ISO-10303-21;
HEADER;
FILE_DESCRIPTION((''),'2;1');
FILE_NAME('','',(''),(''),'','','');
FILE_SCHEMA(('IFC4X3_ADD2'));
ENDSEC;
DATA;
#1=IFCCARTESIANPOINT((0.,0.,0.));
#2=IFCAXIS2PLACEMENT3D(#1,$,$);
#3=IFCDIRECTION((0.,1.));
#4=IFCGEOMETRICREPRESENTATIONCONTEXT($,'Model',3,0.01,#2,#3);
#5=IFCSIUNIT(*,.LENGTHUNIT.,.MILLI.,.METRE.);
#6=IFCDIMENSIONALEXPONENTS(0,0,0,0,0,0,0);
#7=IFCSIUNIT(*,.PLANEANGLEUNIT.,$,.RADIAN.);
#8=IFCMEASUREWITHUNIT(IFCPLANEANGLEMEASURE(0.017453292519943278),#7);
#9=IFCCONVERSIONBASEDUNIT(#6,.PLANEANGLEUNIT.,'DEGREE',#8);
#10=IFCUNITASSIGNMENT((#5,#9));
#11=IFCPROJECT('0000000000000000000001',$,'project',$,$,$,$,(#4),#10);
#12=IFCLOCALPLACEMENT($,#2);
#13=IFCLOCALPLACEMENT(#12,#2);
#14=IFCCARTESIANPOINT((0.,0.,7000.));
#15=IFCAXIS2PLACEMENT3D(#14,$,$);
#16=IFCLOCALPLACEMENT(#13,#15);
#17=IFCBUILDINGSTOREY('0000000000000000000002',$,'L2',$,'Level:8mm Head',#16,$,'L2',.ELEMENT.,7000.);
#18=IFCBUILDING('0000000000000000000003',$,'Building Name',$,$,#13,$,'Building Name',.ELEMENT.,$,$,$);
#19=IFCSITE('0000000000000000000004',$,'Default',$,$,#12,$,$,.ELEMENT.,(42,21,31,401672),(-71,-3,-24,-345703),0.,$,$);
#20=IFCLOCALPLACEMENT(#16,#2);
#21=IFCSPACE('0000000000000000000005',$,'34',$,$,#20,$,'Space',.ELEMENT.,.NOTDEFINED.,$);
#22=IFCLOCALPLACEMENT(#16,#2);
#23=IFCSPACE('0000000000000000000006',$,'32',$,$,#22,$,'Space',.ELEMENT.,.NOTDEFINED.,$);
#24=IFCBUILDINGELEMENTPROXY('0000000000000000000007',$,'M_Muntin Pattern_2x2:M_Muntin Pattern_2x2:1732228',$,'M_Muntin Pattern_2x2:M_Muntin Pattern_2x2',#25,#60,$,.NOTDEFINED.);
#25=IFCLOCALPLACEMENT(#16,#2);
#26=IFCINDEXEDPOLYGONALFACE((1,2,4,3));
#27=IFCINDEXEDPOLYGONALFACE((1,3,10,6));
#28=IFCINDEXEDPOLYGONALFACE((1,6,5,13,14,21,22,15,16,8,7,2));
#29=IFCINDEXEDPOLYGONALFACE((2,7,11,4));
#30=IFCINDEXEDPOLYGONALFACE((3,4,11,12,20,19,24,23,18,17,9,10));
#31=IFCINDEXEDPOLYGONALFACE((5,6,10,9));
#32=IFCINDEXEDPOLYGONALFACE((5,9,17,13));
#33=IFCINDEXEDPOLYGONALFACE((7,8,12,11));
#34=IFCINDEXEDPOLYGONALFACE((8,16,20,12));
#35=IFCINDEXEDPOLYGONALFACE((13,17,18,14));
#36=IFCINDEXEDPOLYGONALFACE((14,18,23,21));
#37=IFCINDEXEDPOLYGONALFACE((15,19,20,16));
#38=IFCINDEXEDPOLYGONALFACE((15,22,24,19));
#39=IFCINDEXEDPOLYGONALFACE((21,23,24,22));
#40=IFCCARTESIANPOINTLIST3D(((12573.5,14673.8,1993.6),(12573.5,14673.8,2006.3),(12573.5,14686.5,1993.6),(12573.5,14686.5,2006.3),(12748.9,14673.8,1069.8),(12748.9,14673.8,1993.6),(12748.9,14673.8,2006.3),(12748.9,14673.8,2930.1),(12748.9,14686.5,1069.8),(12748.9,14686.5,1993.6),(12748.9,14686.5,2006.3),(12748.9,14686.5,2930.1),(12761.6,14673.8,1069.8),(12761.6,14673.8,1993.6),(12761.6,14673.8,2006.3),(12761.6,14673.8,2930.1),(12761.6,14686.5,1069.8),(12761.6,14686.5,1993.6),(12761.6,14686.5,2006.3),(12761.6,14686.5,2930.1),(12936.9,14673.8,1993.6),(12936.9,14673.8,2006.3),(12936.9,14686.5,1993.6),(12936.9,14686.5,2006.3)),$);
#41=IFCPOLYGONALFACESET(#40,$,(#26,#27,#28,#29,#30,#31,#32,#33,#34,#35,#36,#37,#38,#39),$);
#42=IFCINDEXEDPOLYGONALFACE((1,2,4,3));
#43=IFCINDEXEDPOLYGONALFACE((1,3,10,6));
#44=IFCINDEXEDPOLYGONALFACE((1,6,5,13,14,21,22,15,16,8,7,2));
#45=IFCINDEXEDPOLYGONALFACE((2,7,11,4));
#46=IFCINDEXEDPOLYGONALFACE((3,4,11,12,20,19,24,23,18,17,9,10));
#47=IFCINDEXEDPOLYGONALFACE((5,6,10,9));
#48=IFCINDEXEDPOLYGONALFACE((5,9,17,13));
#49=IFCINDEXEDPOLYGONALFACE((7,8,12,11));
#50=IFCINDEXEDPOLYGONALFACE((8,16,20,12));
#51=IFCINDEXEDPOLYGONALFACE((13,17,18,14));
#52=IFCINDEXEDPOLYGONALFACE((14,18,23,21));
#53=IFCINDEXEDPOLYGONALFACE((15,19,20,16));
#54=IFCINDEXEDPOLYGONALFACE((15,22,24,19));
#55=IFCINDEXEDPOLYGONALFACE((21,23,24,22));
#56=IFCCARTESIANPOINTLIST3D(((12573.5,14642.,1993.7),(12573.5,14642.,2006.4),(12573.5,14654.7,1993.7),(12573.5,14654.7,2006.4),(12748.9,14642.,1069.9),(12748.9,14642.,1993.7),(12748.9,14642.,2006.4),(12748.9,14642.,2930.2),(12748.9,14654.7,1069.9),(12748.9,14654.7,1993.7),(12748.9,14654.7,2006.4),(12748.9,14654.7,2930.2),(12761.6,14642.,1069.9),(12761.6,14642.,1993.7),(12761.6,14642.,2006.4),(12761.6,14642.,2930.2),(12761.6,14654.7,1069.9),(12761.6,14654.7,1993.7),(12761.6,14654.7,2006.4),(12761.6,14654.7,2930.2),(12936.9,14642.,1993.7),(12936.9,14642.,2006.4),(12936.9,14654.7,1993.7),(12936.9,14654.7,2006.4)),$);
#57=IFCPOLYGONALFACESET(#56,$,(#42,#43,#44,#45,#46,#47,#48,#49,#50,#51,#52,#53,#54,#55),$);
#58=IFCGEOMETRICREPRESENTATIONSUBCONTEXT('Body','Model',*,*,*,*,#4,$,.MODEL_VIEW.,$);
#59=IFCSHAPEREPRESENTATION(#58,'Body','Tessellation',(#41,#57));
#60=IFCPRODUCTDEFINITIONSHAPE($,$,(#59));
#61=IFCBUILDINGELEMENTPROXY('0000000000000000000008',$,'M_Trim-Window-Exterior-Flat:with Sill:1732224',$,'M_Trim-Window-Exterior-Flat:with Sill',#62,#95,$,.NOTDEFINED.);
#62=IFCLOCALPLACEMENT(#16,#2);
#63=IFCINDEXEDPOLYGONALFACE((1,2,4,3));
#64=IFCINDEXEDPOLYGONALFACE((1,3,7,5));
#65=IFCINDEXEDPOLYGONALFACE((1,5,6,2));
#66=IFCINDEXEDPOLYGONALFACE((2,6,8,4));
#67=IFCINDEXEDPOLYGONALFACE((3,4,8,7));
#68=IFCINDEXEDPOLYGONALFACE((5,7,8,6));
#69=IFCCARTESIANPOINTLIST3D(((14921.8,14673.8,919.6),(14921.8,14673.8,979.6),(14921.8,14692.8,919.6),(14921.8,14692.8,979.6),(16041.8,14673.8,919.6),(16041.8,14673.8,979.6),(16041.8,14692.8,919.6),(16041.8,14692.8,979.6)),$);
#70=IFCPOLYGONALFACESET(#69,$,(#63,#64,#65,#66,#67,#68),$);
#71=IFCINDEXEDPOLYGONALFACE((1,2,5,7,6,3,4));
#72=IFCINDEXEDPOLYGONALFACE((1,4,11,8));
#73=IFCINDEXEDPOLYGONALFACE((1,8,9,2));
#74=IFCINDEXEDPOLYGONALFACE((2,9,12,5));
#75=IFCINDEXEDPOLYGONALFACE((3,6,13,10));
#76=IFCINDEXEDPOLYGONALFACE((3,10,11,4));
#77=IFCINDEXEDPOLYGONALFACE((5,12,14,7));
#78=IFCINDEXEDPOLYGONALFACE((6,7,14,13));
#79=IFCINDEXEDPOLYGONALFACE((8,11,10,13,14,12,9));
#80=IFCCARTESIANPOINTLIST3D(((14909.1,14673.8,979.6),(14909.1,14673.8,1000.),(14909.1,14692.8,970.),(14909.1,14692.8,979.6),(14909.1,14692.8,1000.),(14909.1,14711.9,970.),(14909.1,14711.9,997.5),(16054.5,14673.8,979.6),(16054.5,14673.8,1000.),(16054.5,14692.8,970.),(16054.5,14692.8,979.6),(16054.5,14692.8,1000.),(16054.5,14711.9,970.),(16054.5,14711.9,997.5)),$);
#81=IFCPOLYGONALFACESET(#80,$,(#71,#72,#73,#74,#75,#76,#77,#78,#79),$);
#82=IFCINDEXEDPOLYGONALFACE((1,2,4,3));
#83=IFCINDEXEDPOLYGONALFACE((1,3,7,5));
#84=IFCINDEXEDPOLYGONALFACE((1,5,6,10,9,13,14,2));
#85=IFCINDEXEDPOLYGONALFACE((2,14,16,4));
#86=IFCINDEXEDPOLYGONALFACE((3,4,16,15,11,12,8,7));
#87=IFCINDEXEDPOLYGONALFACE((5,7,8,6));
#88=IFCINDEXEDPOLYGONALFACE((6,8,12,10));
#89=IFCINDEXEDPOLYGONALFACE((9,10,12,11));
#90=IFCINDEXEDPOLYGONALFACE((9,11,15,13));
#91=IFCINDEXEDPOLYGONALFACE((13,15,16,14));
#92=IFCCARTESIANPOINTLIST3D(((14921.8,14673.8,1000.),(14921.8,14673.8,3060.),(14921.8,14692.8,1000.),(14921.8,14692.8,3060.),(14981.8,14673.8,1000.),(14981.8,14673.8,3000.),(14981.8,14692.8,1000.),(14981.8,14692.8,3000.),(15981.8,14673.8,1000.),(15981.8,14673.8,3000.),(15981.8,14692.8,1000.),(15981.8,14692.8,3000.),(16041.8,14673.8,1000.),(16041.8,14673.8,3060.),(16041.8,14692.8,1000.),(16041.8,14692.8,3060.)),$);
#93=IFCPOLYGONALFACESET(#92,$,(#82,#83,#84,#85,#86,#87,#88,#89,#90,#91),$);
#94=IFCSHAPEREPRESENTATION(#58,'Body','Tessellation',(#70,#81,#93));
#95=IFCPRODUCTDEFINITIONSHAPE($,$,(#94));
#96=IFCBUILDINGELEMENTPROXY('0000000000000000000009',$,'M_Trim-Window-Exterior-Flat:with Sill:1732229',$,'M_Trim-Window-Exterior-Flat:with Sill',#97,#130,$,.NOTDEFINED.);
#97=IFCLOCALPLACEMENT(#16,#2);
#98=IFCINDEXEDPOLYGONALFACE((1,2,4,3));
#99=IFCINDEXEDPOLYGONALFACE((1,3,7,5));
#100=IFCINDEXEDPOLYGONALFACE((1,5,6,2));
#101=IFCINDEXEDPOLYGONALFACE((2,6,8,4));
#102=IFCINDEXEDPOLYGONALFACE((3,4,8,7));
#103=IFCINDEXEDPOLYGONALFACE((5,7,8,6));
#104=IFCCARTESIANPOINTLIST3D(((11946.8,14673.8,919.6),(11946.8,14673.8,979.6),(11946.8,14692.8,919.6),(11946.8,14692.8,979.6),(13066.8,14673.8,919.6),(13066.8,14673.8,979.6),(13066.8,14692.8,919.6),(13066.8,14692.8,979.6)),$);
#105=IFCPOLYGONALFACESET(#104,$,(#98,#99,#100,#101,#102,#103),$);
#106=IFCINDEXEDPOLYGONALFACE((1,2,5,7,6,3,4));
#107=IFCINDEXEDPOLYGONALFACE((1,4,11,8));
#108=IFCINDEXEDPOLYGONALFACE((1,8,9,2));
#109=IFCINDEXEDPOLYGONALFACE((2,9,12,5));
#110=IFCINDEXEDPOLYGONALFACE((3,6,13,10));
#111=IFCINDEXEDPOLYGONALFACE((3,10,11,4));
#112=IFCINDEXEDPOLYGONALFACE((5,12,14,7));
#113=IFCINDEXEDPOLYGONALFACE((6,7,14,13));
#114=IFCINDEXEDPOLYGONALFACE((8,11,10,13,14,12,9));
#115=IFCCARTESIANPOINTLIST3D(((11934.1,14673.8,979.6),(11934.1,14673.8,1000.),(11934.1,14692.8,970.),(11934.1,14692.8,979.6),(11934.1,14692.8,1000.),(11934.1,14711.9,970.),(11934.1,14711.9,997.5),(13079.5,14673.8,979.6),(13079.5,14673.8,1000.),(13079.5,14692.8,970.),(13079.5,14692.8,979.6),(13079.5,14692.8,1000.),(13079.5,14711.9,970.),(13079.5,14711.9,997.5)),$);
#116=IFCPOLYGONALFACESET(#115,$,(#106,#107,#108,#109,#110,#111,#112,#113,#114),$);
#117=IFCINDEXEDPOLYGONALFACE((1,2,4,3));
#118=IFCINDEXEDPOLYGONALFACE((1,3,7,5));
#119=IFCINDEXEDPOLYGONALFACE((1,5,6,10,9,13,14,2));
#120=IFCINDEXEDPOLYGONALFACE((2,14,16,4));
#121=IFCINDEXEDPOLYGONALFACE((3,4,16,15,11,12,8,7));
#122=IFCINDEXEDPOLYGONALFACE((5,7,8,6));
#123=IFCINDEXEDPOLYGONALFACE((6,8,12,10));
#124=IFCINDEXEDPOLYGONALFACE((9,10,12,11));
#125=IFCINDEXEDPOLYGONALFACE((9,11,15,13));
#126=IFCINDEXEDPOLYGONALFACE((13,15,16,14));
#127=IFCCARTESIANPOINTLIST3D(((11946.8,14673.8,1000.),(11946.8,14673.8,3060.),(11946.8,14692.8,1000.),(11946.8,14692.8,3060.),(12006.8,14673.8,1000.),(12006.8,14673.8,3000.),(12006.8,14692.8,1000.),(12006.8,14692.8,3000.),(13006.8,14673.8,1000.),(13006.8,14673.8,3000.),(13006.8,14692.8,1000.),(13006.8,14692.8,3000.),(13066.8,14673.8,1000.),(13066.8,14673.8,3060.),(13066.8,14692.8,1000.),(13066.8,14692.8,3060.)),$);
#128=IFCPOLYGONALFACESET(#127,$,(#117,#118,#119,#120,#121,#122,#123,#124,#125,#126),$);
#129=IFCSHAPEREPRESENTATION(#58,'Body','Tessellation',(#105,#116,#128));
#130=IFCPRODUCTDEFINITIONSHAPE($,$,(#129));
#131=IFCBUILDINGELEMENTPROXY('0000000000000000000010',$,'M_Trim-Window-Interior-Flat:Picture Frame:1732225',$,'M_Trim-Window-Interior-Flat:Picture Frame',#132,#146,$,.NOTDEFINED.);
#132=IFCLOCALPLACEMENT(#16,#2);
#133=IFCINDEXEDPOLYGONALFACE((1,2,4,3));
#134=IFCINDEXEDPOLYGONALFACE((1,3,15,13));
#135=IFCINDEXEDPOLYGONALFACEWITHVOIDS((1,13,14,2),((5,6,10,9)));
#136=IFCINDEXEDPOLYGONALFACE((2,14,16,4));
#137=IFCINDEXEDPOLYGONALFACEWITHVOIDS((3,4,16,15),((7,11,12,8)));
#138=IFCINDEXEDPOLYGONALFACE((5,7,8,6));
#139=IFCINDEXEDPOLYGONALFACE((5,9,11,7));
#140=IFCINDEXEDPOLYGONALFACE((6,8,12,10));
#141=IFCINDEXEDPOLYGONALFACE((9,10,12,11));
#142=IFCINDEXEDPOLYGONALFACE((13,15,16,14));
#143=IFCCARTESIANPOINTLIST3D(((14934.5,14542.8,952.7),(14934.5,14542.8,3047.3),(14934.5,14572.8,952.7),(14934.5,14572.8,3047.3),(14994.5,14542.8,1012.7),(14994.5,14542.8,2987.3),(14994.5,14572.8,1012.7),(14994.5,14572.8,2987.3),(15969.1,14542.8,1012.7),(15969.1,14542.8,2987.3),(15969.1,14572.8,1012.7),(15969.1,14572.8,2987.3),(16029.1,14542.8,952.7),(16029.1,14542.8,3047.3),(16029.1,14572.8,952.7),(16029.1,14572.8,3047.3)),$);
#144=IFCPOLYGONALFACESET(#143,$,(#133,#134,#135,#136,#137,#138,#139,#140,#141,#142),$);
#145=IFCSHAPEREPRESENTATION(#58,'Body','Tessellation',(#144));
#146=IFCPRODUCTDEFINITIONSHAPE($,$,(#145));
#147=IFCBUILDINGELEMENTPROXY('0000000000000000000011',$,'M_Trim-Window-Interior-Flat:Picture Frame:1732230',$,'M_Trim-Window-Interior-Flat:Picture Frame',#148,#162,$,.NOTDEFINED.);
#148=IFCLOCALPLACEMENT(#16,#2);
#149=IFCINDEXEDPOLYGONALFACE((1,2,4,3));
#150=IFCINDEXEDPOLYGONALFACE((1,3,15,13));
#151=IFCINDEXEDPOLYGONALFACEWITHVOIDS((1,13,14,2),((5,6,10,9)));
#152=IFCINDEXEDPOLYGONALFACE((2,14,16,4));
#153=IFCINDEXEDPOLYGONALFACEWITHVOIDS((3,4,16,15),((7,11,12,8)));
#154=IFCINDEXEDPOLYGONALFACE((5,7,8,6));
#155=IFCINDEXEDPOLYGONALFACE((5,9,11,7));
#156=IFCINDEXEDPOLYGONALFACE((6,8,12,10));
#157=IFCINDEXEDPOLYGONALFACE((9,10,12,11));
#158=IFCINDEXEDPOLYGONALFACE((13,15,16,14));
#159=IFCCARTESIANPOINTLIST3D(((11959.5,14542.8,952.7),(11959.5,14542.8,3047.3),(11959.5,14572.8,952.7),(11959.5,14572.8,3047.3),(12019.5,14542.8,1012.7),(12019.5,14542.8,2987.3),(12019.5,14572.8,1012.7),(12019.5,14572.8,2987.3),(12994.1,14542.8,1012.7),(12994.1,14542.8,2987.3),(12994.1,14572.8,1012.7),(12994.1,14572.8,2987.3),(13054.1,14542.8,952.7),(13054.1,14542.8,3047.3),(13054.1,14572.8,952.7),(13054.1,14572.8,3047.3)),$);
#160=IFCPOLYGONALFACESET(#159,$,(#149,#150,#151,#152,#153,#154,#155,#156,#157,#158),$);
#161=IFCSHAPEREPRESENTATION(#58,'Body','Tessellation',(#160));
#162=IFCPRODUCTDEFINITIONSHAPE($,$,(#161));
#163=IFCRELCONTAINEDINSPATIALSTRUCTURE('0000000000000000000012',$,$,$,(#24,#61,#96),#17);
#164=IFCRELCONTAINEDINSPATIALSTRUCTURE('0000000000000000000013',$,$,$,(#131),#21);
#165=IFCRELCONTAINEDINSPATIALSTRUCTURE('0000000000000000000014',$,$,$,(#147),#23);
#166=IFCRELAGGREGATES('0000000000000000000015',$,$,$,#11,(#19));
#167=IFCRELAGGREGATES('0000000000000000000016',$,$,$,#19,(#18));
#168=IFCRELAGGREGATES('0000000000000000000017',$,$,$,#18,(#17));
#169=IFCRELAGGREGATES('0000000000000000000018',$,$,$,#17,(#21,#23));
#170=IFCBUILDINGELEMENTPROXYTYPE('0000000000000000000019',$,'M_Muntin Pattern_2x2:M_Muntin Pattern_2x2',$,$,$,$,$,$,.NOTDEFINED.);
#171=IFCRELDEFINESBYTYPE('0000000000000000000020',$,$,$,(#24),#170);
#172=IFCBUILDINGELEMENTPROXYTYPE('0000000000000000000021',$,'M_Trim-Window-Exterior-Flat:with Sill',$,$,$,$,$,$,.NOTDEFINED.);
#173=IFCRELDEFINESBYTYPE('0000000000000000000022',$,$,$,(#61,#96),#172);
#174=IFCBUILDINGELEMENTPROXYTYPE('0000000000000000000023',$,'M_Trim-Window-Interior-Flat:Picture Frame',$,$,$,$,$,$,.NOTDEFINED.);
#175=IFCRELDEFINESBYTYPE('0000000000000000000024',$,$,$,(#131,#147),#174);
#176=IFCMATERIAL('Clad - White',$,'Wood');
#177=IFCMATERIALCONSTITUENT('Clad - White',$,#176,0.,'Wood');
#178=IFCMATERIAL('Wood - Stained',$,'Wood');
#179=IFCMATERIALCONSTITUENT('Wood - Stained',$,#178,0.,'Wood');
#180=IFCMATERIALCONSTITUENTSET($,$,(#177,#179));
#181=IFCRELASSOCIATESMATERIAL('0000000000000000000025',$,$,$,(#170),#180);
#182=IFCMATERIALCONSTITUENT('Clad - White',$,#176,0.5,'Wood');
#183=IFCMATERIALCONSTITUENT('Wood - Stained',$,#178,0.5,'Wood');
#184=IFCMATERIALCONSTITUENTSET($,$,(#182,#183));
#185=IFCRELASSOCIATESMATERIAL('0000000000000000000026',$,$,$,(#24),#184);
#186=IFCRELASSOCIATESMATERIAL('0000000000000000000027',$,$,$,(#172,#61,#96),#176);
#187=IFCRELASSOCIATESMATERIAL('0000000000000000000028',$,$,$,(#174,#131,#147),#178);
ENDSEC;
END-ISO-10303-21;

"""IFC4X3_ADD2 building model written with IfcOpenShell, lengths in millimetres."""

from ifc_helpers import new_model, entity, si_unit, converted_unit, direction, frame, frame_2d, origin, place, context, subcontext, project, spatial, polyline, rectangle, outline, extrude, source, transform, mapped, material, constituent, constituent_set, type_object, type_shapes, element, save


model = new_model("IFC4X3_ADD2")

# Units and contexts
model_context = context("Model", 3, precision=0.01, world=origin(), true_north=direction((0.0, 1.0)))
body_context = subcontext(model_context, "Body", "Model", "MODEL_VIEW")
ifc_project = project(units=[si_unit("LENGTHUNIT", "METRE", prefix="MILLI"), converted_unit("PLANEANGLEUNIT", "DEGREE", entity("IfcPlaneAngleMeasure", 0.017453292519943278), si_unit("PLANEANGLEUNIT", "RADIAN"), dimensions=[0, 0, 0, 0, 0, 0, 0])], contexts=[model_context])

# Site, building, storey
site_placement = place(None, origin())
site = spatial("IfcSite", under=ifc_project, at=site_placement, Name="Default", CompositionType="ELEMENT", RefLatitude=(42, 21, 31, 401672), RefLongitude=(-71, -3, -24, -345703), RefElevation=0.0)
building_placement = place(site_placement, origin())
building = spatial("IfcBuilding", under=site, at=building_placement, Name="Building Name", LongName="Building Name", CompositionType="ELEMENT")
storey_placement = place(building_placement, frame((0.0, 0.0, 7000.0)))
storey = spatial("IfcBuildingStorey", under=building, at=storey_placement, Name="L2", ObjectType="Level:8mm Head", LongName="L2", CompositionType="ELEMENT", Elevation=7000.0)

# Building element proxies
ifc_material_1 = material(Name="Clad - White", Category="Wood")
ifc_material_2 = material(Name="Wood - Stained", Category="Wood")
ifc_constituent_1 = constituent(ifc_material_1, Name="Clad - White", Category="Wood", fraction=0.0)
ifc_constituent_2 = constituent(ifc_material_2, Name="Wood - Stained", Category="Wood", fraction=0.0)
ifc_constituent_set_1 = constituent_set(constituents=[ifc_constituent_1, ifc_constituent_2])
building_element_proxy_type_1 = type_object("IfcBuildingElementProxyType", Name="M_Muntin Pattern_2x2:M_Muntin Pattern_2x2", PredefinedType="NOTDEFINED", material=ifc_constituent_set_1)
shared_shape_1 = source(origin(), body_context, "Body", "SweptSolid", [
    extrude(outline(polyline([(6.4, -6.4), (930.1, -6.4), (930.1, 6.3), (6.4, 6.3), (6.4, 181.7), (-6.3, 181.7), (-6.3, 6.3), (-930.2, 6.3), (-930.2, -6.4), (-6.3, -6.4), (-6.3, -181.7), (6.4, -181.7), (6.4, -6.4)])), frame((0.0, -22.2, 930.1), z_axis=(0.0, 1.0, 0.0), x_axis=(0.0, 0.0, 1.0)), (0.0, 0.0, 1.0), 12.7),
    extrude(outline(polyline([(6.4, -6.4), (930.2, -6.4), (930.2, 6.3), (6.4, 6.3), (6.4, 181.7), (-6.3, 181.7), (-6.3, 6.3), (-930.2, 6.3), (-930.2, -6.4), (-6.3, -6.4), (-6.3, -181.7), (6.4, -181.7), (6.4, -6.4)])), frame((0.0, 9.5, 930.2), z_axis=(0.0, 1.0, 0.0), x_axis=(0.0, 0.0, 1.0)), (0.0, 0.0, 1.0), 12.7),
])
type_shapes(building_element_proxy_type_1, [shared_shape_1])
ifc_constituent_3 = constituent(ifc_material_1, Name="Clad - White", Category="Wood", fraction=0.5)
ifc_constituent_4 = constituent(ifc_material_2, Name="Wood - Stained", Category="Wood", fraction=0.5)
ifc_constituent_set_2 = constituent_set(constituents=[ifc_constituent_3, ifc_constituent_4])
proxy_1_placement = place(storey_placement, frame((12755.2, 14664.3, 1069.9), z_axis=(0.0, 0.0, 1.0), x_axis=(-1.0, 0.0, 0.0)))
element("IfcBuildingElementProxy", 1, at=proxy_1_placement, inside=storey, type_object=building_element_proxy_type_1, material=ifc_constituent_set_2, Name="M_Muntin Pattern_2x2:M_Muntin Pattern_2x2:1732228", ObjectType="M_Muntin Pattern_2x2:M_Muntin Pattern_2x2", PredefinedType="NOTDEFINED", context=body_context, shape_type="MappedRepresentation", body=[
    mapped(shared_shape_1, transform((0.0, 0.0, 0.0), scale=1.0)),
])
building_element_proxy_type_2 = type_object("IfcBuildingElementProxyType", Name="M_Trim-Window-Exterior-Flat:with Sill", PredefinedType="NOTDEFINED", material=ifc_material_1)
shared_shape_2 = source(origin(), body_context, "Body", "SweptSolid", [
    extrude(rectangle(XDim=1120.0, YDim=60.0, at=frame_2d((0.0, 0.0), x_axis=(1.0, 0.0))), frame((0.0, -2050.4, 0.0), z_axis=(0.0, 0.0, 1.0), x_axis=(-1.0, 0.0, 0.0)), (0.0, 0.0, 1.0), 19.0),
    extrude(outline(polyline([(-19.0, -15.2), (0.0, -15.2), (0.0, -5.7), (19.0, -5.7), (19.0, 14.8), (0.0, 14.8), (-19.0, 12.3), (-19.0, -15.2)])), frame((-572.7, -2014.8, 19.0), z_axis=(1.0, 0.0, 0.0), x_axis=(0.0, 0.0, -1.0)), (0.0, 0.0, 1.0), 1145.4),
    extrude(outline(polyline([(-1045.0, -560.0), (1015.0, -560.0), (1015.0, -500.0), (-985.0, -500.0), (-985.0, 500.0), (1015.0, 500.0), (1015.0, 560.0), (-1045.0, 560.0), (-1045.0, -560.0)])), frame((0.0, -985.0, 0.0), z_axis=(0.0, 0.0, 1.0), x_axis=(0.0, -1.0, 0.0)), (0.0, 0.0, 1.0), 19.0),
])
type_shapes(building_element_proxy_type_2, [shared_shape_2])
for number, where, z_axis, x_axis, name in (
    (2, (15481.8, 14673.8, 3000.0), (0.0, 1.0, 0.0), (-1.0, 0.0, 0.0), "M_Trim-Window-Exterior-Flat:with Sill:1732224"),
    (3, (12506.8, 14673.8, 3000.0), (0.0, 1.0, 0.0), (-1.0, 0.0, 0.0), "M_Trim-Window-Exterior-Flat:with Sill:1732229"),
):
    element("IfcBuildingElementProxy", number, at=place(storey_placement, frame(where, z_axis=z_axis, x_axis=x_axis)), inside=storey, type_object=building_element_proxy_type_2, material=ifc_material_1, Name=name, ObjectType="M_Trim-Window-Exterior-Flat:with Sill", PredefinedType="NOTDEFINED", context=body_context, shape_type="MappedRepresentation", body=[
        mapped(shared_shape_2, transform((0.0, 0.0, 0.0), scale=1.0)),
    ])

# Shared definitions
space_1_placement = place(storey_placement, origin())
space_1 = spatial("IfcSpace", under=storey, at=space_1_placement, Name="34", LongName="Space", CompositionType="ELEMENT", PredefinedType="NOTDEFINED")

# Building element proxy
building_element_proxy_type_3 = type_object("IfcBuildingElementProxyType", Name="M_Trim-Window-Interior-Flat:Picture Frame", PredefinedType="NOTDEFINED", material=ifc_material_2)
shared_shape_3 = source(origin(), body_context, "Body", "SweptSolid", [
    extrude(outline(polyline([(-547.3, -1047.3), (547.3, -1047.3), (547.3, 1047.3), (-547.3, 1047.3), (-547.3, -1047.3)]), holes=[polyline([(-487.3, -987.3), (-487.3, 987.3), (487.3, 987.3), (487.3, -987.3), (-487.3, -987.3)])]), frame((0.0, -1000.0, 0.0), z_axis=(0.0, 0.0, 1.0), x_axis=(-1.0, 0.0, 0.0)), (0.0, 0.0, 1.0), 30.0),
])
type_shapes(building_element_proxy_type_3, [shared_shape_3])
proxy_2_placement = place(space_1_placement, frame((15481.8, 14572.8, 3000.0), z_axis=(0.0, -1.0, 0.0), x_axis=(1.0, 0.0, 0.0)))
element("IfcBuildingElementProxy", 4, at=proxy_2_placement, inside=space_1, type_object=building_element_proxy_type_3, material=ifc_material_2, Name="M_Trim-Window-Interior-Flat:Picture Frame:1732225", ObjectType="M_Trim-Window-Interior-Flat:Picture Frame", PredefinedType="NOTDEFINED", context=body_context, shape_type="MappedRepresentation", body=[
    mapped(shared_shape_3, transform((0.0, 0.0, 0.0), scale=1.0)),
])

# Shared definitions
space_2_placement = place(storey_placement, origin())
space_2 = spatial("IfcSpace", under=storey, at=space_2_placement, Name="32", LongName="Space", CompositionType="ELEMENT", PredefinedType="NOTDEFINED")

# Building element proxy
proxy_3_placement = place(space_2_placement, frame((12506.8, 14572.8, 3000.0), z_axis=(0.0, -1.0, 0.0), x_axis=(1.0, 0.0, 0.0)))
element("IfcBuildingElementProxy", 5, at=proxy_3_placement, inside=space_2, type_object=building_element_proxy_type_3, material=ifc_material_2, Name="M_Trim-Window-Interior-Flat:Picture Frame:1732230", ObjectType="M_Trim-Window-Interior-Flat:Picture Frame", PredefinedType="NOTDEFINED", context=body_context, shape_type="MappedRepresentation", body=[
    mapped(shared_shape_3, transform((0.0, 0.0, 0.0), scale=1.0)),
])

save(model, "model.ifc")
